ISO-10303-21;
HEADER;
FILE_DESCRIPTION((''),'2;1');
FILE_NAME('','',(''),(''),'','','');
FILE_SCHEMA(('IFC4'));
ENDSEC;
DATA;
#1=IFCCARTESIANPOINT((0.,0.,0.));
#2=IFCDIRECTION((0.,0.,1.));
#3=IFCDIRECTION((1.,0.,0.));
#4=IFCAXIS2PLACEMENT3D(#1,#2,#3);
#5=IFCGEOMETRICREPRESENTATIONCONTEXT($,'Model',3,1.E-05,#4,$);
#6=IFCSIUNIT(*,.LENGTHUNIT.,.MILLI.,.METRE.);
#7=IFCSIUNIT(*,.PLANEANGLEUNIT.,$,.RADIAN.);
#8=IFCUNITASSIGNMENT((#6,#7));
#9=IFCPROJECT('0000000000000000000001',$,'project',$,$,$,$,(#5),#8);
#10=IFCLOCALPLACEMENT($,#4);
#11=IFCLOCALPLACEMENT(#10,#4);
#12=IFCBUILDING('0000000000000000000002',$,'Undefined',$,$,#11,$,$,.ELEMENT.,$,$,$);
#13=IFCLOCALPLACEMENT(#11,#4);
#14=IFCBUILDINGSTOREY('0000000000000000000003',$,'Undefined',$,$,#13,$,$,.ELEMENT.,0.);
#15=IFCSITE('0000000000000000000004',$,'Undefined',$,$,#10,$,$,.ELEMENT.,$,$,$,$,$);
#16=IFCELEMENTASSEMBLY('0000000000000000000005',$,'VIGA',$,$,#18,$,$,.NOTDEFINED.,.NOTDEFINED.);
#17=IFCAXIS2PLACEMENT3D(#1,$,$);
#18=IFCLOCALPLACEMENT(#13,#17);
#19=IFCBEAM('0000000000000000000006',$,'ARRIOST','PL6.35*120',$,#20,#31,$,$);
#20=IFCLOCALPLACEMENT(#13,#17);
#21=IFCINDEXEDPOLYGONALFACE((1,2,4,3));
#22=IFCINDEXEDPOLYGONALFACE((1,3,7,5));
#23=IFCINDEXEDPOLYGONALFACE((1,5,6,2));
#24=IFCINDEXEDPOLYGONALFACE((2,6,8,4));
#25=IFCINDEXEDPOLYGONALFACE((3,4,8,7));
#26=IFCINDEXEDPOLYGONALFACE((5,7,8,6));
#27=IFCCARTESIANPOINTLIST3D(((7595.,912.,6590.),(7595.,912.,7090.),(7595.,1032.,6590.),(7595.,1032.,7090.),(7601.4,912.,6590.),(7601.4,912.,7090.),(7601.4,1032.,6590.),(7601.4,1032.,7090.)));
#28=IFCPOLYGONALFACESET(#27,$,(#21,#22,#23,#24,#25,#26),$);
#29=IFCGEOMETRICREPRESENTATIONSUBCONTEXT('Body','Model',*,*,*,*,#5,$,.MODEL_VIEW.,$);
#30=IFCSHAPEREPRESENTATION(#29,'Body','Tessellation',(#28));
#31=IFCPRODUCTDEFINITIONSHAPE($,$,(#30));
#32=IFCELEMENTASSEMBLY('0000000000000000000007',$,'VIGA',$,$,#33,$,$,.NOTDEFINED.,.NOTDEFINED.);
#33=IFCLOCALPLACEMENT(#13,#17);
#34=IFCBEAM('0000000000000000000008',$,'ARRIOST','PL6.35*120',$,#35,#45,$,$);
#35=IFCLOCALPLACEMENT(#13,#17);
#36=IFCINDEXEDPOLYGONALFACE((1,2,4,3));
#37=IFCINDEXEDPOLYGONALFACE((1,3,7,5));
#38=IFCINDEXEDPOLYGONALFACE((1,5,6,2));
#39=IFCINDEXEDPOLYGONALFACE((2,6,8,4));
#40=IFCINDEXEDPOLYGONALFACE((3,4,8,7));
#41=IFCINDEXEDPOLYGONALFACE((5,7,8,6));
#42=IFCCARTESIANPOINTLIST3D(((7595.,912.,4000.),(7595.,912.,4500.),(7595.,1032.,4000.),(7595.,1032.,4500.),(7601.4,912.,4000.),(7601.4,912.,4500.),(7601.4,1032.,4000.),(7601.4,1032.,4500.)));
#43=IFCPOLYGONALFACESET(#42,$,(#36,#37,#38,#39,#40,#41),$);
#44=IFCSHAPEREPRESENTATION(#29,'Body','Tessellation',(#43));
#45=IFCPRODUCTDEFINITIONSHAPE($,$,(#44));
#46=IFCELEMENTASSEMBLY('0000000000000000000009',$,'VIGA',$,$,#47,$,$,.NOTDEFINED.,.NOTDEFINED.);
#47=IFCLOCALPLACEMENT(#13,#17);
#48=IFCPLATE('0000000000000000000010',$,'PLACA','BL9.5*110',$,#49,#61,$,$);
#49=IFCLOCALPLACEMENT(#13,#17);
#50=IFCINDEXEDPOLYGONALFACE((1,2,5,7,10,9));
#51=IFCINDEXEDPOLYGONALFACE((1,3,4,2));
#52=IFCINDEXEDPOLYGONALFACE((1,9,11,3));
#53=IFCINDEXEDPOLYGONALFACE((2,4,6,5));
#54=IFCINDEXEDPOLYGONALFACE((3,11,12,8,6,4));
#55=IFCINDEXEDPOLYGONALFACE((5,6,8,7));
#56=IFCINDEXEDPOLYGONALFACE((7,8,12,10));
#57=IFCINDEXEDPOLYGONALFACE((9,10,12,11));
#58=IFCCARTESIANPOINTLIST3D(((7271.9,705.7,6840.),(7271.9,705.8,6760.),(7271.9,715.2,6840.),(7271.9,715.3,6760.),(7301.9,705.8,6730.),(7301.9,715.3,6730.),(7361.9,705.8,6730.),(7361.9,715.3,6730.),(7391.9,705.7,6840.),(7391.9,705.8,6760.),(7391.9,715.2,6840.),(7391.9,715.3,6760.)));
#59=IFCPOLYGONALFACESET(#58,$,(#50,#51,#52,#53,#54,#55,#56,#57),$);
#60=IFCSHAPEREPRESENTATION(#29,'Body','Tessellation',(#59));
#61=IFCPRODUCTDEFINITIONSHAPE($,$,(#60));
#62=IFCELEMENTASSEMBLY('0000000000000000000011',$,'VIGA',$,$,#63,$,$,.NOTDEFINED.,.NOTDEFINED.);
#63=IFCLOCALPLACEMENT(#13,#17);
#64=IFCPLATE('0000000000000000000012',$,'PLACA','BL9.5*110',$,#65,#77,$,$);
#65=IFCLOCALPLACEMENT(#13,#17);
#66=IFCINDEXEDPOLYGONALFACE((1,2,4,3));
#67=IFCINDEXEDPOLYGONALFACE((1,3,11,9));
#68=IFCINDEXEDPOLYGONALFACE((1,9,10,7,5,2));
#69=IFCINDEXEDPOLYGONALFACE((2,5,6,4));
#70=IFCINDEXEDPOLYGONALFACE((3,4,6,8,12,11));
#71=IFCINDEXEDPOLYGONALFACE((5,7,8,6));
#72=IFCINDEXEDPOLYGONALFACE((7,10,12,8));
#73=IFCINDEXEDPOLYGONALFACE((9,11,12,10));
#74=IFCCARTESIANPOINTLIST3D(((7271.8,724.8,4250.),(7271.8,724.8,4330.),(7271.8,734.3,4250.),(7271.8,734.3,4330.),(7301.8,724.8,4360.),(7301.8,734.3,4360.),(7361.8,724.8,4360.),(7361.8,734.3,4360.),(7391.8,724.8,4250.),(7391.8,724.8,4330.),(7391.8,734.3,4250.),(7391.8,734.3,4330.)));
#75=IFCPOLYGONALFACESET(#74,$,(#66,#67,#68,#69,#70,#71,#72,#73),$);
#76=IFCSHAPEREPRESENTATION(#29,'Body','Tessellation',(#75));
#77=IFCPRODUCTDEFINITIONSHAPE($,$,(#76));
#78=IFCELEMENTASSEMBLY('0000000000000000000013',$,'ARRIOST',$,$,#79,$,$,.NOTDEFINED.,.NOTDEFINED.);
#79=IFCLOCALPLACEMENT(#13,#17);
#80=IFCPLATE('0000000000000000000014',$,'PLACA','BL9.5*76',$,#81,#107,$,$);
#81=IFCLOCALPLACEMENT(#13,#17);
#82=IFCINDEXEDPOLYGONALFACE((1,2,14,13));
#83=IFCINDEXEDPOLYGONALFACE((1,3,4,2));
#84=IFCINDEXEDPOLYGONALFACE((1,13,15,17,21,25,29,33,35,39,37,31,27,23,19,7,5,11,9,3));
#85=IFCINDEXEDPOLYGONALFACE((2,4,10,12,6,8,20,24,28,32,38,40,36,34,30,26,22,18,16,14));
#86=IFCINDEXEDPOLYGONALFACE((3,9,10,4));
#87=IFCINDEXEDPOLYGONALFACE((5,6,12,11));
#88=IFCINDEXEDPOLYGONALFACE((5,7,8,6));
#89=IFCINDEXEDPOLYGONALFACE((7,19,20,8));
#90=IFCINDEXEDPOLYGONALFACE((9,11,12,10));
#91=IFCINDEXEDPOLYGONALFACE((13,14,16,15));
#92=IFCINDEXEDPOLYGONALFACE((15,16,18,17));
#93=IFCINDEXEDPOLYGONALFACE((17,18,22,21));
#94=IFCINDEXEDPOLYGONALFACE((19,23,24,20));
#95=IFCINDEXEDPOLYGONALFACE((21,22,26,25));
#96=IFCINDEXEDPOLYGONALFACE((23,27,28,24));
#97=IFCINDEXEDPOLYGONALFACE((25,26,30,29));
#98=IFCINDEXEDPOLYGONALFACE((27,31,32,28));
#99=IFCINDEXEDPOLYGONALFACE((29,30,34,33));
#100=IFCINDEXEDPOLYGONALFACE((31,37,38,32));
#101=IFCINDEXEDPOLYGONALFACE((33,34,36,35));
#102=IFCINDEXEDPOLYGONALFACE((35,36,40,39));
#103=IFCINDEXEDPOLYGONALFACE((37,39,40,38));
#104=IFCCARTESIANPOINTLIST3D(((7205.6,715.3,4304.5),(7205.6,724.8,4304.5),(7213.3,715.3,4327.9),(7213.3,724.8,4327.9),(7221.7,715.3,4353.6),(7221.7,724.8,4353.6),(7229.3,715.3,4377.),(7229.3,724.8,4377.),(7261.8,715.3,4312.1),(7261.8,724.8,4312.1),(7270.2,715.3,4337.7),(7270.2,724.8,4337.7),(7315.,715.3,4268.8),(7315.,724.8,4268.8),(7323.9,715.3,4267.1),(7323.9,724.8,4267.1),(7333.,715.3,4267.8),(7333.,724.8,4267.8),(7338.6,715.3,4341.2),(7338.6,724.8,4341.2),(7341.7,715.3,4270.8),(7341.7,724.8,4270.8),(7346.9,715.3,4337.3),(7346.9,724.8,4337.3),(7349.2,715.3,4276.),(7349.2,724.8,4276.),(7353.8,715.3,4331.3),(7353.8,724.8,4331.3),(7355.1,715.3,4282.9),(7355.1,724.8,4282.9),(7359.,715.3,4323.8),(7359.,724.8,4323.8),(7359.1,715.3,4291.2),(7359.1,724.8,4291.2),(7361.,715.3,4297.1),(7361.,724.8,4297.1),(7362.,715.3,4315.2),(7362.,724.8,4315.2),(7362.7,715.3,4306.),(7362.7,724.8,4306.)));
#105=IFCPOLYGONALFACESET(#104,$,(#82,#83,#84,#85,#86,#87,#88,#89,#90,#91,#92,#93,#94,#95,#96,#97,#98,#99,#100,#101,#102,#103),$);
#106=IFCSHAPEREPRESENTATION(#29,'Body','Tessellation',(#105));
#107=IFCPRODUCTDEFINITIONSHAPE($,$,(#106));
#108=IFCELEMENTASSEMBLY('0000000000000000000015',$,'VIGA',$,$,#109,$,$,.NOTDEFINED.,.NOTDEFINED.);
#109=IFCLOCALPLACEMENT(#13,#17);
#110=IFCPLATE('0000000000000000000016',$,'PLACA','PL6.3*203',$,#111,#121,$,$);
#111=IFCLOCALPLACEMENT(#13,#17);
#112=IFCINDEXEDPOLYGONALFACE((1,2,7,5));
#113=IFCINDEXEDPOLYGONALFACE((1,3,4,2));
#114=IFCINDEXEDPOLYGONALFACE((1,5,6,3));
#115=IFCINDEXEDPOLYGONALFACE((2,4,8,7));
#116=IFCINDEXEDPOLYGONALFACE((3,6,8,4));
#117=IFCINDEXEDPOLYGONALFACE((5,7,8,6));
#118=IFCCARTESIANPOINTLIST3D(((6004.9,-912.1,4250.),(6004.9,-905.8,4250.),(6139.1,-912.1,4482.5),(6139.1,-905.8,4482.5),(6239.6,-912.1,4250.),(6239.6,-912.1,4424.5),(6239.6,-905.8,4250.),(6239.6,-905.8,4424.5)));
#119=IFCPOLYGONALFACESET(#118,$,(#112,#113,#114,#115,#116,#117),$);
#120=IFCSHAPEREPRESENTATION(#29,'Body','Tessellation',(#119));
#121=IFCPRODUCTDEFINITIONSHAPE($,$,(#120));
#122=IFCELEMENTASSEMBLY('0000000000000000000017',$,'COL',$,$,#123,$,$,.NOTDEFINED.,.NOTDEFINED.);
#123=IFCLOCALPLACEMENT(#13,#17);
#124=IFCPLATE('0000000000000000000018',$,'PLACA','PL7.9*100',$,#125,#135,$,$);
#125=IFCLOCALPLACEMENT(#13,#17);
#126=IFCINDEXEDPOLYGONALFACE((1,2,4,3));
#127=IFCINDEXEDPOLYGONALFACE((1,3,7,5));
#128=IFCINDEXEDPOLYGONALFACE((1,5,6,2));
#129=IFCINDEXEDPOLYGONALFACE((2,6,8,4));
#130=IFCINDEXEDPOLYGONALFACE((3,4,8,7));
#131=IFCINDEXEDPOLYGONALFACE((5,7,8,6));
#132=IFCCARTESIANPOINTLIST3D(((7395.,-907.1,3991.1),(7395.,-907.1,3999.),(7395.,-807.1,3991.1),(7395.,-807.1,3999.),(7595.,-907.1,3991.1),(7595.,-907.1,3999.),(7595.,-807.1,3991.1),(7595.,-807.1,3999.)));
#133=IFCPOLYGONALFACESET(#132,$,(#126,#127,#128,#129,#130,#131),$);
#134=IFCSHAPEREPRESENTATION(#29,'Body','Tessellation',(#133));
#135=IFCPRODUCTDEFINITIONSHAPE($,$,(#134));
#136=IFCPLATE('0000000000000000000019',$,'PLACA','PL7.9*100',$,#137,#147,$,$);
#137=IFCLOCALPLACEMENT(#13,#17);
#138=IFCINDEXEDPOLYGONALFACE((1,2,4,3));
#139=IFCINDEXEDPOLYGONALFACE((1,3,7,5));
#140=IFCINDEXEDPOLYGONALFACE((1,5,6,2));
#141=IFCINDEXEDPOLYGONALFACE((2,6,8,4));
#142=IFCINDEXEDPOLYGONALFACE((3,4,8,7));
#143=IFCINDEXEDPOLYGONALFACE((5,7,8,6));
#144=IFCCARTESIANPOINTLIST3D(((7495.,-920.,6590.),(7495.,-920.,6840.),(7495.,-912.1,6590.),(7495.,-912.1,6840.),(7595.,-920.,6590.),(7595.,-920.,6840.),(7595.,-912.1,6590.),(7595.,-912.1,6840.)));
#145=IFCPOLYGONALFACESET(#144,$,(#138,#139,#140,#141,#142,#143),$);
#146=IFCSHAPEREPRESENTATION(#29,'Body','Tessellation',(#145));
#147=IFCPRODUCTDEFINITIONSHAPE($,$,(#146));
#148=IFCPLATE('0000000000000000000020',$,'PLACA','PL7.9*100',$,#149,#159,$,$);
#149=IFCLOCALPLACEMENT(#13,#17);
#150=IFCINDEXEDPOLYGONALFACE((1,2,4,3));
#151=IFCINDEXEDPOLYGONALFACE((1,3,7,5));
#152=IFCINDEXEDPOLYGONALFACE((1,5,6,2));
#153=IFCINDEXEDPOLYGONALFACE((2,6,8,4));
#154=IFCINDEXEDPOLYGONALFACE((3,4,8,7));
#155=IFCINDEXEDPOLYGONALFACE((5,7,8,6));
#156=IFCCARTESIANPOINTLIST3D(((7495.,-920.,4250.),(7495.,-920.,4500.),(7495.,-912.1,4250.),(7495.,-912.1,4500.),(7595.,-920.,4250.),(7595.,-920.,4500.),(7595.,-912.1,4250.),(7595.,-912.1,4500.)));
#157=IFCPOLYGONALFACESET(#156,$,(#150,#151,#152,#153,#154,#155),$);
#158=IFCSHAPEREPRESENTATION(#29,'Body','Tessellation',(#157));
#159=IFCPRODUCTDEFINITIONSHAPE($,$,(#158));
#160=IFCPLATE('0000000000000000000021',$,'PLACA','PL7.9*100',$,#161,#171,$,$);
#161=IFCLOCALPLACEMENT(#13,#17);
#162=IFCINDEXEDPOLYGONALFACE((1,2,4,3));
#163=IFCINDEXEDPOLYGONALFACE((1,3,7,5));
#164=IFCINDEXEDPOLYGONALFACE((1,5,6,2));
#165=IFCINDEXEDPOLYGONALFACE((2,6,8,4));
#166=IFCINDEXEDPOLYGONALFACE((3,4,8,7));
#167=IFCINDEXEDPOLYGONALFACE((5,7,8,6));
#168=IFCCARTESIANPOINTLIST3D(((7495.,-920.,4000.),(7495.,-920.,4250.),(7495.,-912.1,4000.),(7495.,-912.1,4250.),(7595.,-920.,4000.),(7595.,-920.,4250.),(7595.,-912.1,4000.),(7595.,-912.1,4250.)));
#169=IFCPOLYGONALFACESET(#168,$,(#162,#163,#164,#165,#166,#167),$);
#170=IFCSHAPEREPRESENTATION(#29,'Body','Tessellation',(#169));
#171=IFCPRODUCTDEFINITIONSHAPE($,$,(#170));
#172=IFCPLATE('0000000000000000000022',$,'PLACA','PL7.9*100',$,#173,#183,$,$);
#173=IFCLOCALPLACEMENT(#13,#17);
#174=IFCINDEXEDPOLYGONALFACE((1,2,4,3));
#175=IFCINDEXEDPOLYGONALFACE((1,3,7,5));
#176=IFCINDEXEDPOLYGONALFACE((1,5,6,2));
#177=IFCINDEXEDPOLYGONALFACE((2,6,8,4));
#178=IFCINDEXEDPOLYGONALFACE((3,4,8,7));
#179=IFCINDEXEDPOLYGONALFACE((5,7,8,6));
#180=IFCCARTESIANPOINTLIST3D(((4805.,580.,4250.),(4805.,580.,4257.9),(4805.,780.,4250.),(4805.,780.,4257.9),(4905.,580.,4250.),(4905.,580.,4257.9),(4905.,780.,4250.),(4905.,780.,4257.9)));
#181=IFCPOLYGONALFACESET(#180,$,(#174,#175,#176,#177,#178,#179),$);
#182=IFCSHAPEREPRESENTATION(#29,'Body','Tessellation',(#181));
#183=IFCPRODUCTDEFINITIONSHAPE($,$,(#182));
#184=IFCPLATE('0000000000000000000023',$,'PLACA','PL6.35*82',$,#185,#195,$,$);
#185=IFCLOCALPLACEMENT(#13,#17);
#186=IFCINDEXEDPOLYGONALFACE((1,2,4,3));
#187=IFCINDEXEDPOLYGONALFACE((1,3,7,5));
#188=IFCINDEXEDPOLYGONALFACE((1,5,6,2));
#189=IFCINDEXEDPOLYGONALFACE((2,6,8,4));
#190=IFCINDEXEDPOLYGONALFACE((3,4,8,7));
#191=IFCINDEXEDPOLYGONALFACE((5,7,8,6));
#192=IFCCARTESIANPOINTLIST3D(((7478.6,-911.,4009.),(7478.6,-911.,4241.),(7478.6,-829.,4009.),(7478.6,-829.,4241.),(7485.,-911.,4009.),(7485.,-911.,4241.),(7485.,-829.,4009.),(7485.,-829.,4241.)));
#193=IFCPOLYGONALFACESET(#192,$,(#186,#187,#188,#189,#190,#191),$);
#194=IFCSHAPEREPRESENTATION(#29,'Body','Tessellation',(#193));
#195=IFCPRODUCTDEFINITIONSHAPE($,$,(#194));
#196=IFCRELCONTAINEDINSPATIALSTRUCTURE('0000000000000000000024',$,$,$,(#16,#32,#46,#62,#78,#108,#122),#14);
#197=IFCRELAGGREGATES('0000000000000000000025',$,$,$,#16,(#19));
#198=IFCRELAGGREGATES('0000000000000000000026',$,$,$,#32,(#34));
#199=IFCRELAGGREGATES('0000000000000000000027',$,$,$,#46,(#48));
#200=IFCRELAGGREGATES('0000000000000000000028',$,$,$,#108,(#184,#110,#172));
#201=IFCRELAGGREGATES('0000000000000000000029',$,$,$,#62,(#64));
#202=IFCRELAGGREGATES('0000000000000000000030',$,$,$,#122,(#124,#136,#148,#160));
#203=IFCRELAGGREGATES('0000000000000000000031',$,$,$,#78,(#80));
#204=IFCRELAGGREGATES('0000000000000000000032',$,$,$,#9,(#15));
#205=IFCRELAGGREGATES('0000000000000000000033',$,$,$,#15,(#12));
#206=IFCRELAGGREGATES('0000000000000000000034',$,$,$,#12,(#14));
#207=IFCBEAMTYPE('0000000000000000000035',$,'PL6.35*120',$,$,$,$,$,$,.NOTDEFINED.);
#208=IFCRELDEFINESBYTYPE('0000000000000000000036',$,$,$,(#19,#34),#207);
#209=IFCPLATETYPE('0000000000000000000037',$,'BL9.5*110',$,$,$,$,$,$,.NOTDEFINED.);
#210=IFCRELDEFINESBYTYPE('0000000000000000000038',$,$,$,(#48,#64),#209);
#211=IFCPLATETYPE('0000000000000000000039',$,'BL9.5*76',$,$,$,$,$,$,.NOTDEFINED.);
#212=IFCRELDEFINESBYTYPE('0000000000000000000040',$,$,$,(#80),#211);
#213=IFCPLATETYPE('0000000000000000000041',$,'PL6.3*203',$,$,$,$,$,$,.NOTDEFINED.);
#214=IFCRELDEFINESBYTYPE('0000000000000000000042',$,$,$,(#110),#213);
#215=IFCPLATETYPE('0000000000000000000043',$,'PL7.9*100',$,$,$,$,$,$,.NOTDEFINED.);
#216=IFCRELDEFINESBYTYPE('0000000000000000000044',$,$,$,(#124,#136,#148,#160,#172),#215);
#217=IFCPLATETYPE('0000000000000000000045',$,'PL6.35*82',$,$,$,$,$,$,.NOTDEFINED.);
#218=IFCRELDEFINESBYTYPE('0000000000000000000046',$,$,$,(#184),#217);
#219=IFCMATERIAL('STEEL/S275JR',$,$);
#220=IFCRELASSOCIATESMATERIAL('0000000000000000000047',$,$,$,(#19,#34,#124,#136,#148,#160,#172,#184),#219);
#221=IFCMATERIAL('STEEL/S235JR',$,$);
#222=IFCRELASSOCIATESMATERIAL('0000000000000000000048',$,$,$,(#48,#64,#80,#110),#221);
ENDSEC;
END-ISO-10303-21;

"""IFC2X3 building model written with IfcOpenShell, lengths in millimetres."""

from ifc_helpers import new_model, si_unit, frame, frame_2d, origin_with_axes, origin_2d_with_axis, place, context, subcontext, project, spatial, polyline, circle_curve, parameter, trimmed, segment, composite_curve, rectangle, outline, extrude, boolean, material, type_object, element, aggregate, save


model = new_model("IFC2X3")

# Units and contexts
model_context = context("Model", 3, precision=1e-05, world=origin_with_axes())
body_context = subcontext(model_context, "Body", "Model", "MODEL_VIEW")
ifc_project = project(units=[si_unit("LENGTHUNIT", "METRE", prefix="MILLI"), si_unit("PLANEANGLEUNIT", "RADIAN")], contexts=[model_context])

# Site, building, storey
site_placement = place(None, origin_with_axes())
site = spatial("IfcSite", under=ifc_project, at=site_placement, Name="Undefined", CompositionType="ELEMENT")
building_placement = place(site_placement, origin_with_axes())
building = spatial("IfcBuilding", under=site, at=building_placement, Name="Undefined", CompositionType="ELEMENT")
storey_placement = place(building_placement, origin_with_axes())
storey = spatial("IfcBuildingStorey", under=building, at=storey_placement, Name="Undefined", CompositionType="ELEMENT", Elevation=0.0)

# Element assemblies, beams
assembly_1_placement = place(storey_placement, origin_with_axes())
assembly_1 = element("IfcElementAssembly", 1, at=assembly_1_placement, inside=storey, Name="VIGA", AssemblyPlace="NOTDEFINED", PredefinedType="NOTDEFINED")
ifc_material_1 = material(Name="STEEL/S275JR")
beam_type = type_object("IfcBeamType", Name="PL6.35*120", PredefinedType="NOTDEFINED")
beam_1_placement = place(assembly_1_placement, frame((7598.2, 972.0, 6590.0), z_axis=(0.0, 1.0, 0.0), x_axis=(0.0, 0.0, 1.0)))
beam_1 = element("IfcBeam", 2, at=beam_1_placement, type_object=beam_type, material=ifc_material_1, Name="ARRIOST", Description="PL6.35*120", context=body_context, shape_type="SweptSolid", body=[
    extrude(rectangle(XDim=6.3, YDim=120.0, at=origin_2d_with_axis()), frame((500.0, 0.0, 0.0), z_axis=(-1.0, 0.0, 0.0), x_axis=(0.0, -1.0, 0.0)), (0.0, 0.0, 1.0), 500.0),
])
aggregate(assembly_1, [beam_1])
assembly_2_placement = place(storey_placement, origin_with_axes())
assembly_2 = element("IfcElementAssembly", 3, at=assembly_2_placement, inside=storey, Name="VIGA", AssemblyPlace="NOTDEFINED", PredefinedType="NOTDEFINED")
beam_2_placement = place(assembly_2_placement, frame((7598.2, 972.0, 4000.0), z_axis=(0.0, 1.0, 0.0), x_axis=(0.0, 0.0, 1.0)))
beam_2 = element("IfcBeam", 4, at=beam_2_placement, type_object=beam_type, material=ifc_material_1, Name="ARRIOST", Description="PL6.35*120", context=body_context, shape_type="SweptSolid", body=[
    extrude(rectangle(XDim=6.3, YDim=120.0, at=origin_2d_with_axis()), frame((500.0, 0.0, 0.0), z_axis=(-1.0, 0.0, 0.0), x_axis=(0.0, -1.0, 0.0)), (0.0, 0.0, 1.0), 500.0),
])
aggregate(assembly_2, [beam_2])

# Element assemblies, plates
assembly_3_placement = place(storey_placement, origin_with_axes())
assembly_3 = element("IfcElementAssembly", 5, at=assembly_3_placement, inside=storey, Name="VIGA", AssemblyPlace="NOTDEFINED", PredefinedType="NOTDEFINED")
ifc_material_2 = material(Name="STEEL/S235JR")
plate_type_1 = type_object("IfcPlateType", Name="BL9.5*110", PredefinedType="NOTDEFINED")
plate_1_placement = place(assembly_3_placement, frame((7271.9, 710.5, 6760.0), z_axis=(0.0, 1.0, 0.000014), x_axis=(0.0, -0.000014, 1.0)))
plate_1 = element("IfcPlate", 6, at=plate_1_placement, type_object=plate_type_1, material=ifc_material_2, Name="PLACA", Description="BL9.5*110", context=body_context, shape_type="SweptSolid", body=[
    extrude(outline(polyline([(0.0, 0.0), (80.0, 0.0), (80.0, 120.0), (0.0, 120.0), (-30.0, 90.0), (-30.0, 30.0), (0.0, 0.0)])), frame((0.0, 0.0, -4.7), z_axis=(0.0, 0.0, 1.0), x_axis=(1.0, 0.0, 0.0)), (0.0, 0.0, 1.0), 9.5),
])
aggregate(assembly_3, [plate_1])
assembly_4_placement = place(storey_placement, origin_with_axes())
assembly_4 = element("IfcElementAssembly", 7, at=assembly_4_placement, inside=storey, Name="VIGA", AssemblyPlace="NOTDEFINED", PredefinedType="NOTDEFINED")
plate_2_placement = place(assembly_4_placement, frame((7271.8, 729.5, 4330.0), z_axis=(0.0, -1.0, -0.000007), x_axis=(0.0, 0.000007, -1.0)))
plate_2 = element("IfcPlate", 8, at=plate_2_placement, type_object=plate_type_1, material=ifc_material_2, Name="PLACA", Description="BL9.5*110", context=body_context, shape_type="SweptSolid", body=[
    extrude(outline(polyline([(0.0, 0.0), (80.0, 0.0), (80.0, 120.0), (0.0, 120.0), (-30.0, 90.0), (-30.0, 30.0), (0.0, 0.0)])), frame((0.0, 0.0, -4.7), z_axis=(0.0, 0.0, 1.0), x_axis=(1.0, 0.0, 0.0)), (0.0, 0.0, 1.0), 9.5),
])
assembly_5_placement = place(storey_placement, origin_with_axes())
assembly_5 = element("IfcElementAssembly", 9, at=assembly_5_placement, inside=storey, Name="ARRIOST", AssemblyPlace="NOTDEFINED", PredefinedType="NOTDEFINED")
plate_type_2 = type_object("IfcPlateType", Name="BL9.5*76", PredefinedType="NOTDEFINED")
plate_3_placement = place(assembly_5_placement, frame((7348.2, 720.0, 4257.9), z_axis=(0.0, -1.0, -0.000007), x_axis=(0.310823, -0.000007, 0.950468)))
plate_3 = element("IfcPlate", 10, at=plate_3_placement, type_object=plate_type_2, material=ifc_material_2, Name="PLACA", Description="BL9.5*76", context=body_context, shape_type="CSG", body=[
    boolean("DIFFERENCE", extrude(outline(composite_curve([segment(trimmed(circle_curve(frame_2d((35.0, 35.0), x_axis=(-1.0, 0.0)), 35.0), [parameter(0.0)], [parameter(1.570796)], True, "PARAMETER"), True, "CONTINUOUS"), segment(polyline([(35.0, 0.0), (41.2, 0.0)]), True, "CONTINUOUS"), segment(trimmed(circle_curve(frame_2d((41.2, 35.0), x_axis=(0.0, -1.0)), 35.0), [parameter(0.0)], [parameter(1.570796)], True, "PARAMETER"), True, "CONTINUOUS"), segment(polyline([(76.2, 35.0), (76.2, 150.0), (0.0, 150.0), (0.0, 35.0)]), True, "CONTINUOUS")], self_intersect=True)), frame((0.0, 0.0, -4.7), z_axis=(0.0, 0.0, 1.0), x_axis=(1.0, 0.0, 0.0)), (0.0, 0.0, 1.0), 9.5), extrude(rectangle(XDim=27.0, YDim=27.0, at=origin_2d_with_axis()), frame((38.1, 250.0, 0.0), z_axis=(0.0, -1.0, 0.0), x_axis=(1.0, 0.0, 0.0)), (0.0, 0.0, 1.0), 151.0)),
])
assembly_6_placement = place(storey_placement, origin_with_axes())
assembly_6 = element("IfcElementAssembly", 11, at=assembly_6_placement, inside=storey, Name="VIGA", AssemblyPlace="NOTDEFINED", PredefinedType="NOTDEFINED")
plate_type_3 = type_object("IfcPlateType", Name="PL6.3*203", PredefinedType="NOTDEFINED")
plate_4_placement = place(assembly_6_placement, frame((6239.6, -909.0, 4250.0), z_axis=(0.0, 1.0, 0.0), x_axis=(-1.0, 0.0, 0.0)))
plate_4 = element("IfcPlate", 12, at=plate_4_placement, type_object=plate_type_3, material=ifc_material_2, Name="PLACA", Description="PL6.3*203", context=body_context, shape_type="SweptSolid", body=[
    extrude(outline(polyline([(0.0, 0.0), (234.7, 0.0), (100.5, 232.5), (0.0, 174.5), (0.0, 0.0)])), frame((0.0, 0.0, -3.1), z_axis=(0.0, 0.0, 1.0), x_axis=(1.0, 0.0, 0.0)), (0.0, 0.0, 1.0), 6.3),
])

# Element assembly, plates
assembly_7_placement = place(storey_placement, origin_with_axes())
assembly_7 = element("IfcElementAssembly", 13, at=assembly_7_placement, inside=storey, Name="COL", AssemblyPlace="NOTDEFINED", PredefinedType="NOTDEFINED")
plate_type_4 = type_object("IfcPlateType", Name="PL7.9*100", PredefinedType="NOTDEFINED")
plate_5_placement = place(assembly_7_placement, frame((7395.0, -807.1, 3995.0), z_axis=(0.0, 0.0, 1.0), x_axis=(0.0, -1.0, 0.0)))
plate_5 = element("IfcPlate", 14, at=plate_5_placement, type_object=plate_type_4, material=ifc_material_1, Name="PLACA", Description="PL7.9*100", context=body_context, shape_type="SweptSolid", body=[
    extrude(outline(polyline([(0.0, 0.0), (100.0, 0.0), (100.0, 200.0), (0.0, 200.0), (0.0, 0.0)])), frame((0.0, 0.0, -4.0), z_axis=(0.0, 0.0, 1.0), x_axis=(1.0, 0.0, 0.0)), (0.0, 0.0, 1.0), 7.9),
])
plate_6_placement = place(assembly_7_placement, frame((7495.0, -916.0, 6590.0), z_axis=(0.0, 1.0, 0.0), x_axis=(0.0, 0.0, 1.0)))
plate_6 = element("IfcPlate", 15, at=plate_6_placement, type_object=plate_type_4, material=ifc_material_1, Name="PLACA", Description="PL7.9*100", context=body_context, shape_type="SweptSolid", body=[
    extrude(outline(polyline([(0.0, 0.0), (250.0, 0.0), (250.0, 100.0), (0.0, 100.0), (0.0, 0.0)])), frame((0.0, 0.0, -4.0), z_axis=(0.0, 0.0, 1.0), x_axis=(1.0, 0.0, 0.0)), (0.0, 0.0, 1.0), 7.9),
])
plate_7_placement = place(assembly_7_placement, frame((7495.0, -916.0, 4250.0), z_axis=(0.0, 1.0, 0.0), x_axis=(0.0, 0.0, 1.0)))
plate_7 = element("IfcPlate", 16, at=plate_7_placement, type_object=plate_type_4, material=ifc_material_1, Name="PLACA", Description="PL7.9*100", context=body_context, shape_type="SweptSolid", body=[
    extrude(outline(polyline([(0.0, 0.0), (250.0, 0.0), (250.0, 100.0), (0.0, 100.0), (0.0, 0.0)])), frame((0.0, 0.0, -4.0), z_axis=(0.0, 0.0, 1.0), x_axis=(1.0, 0.0, 0.0)), (0.0, 0.0, 1.0), 7.9),
])
plate_8_placement = place(assembly_7_placement, frame((7495.0, -916.0, 4000.0), z_axis=(0.0, 1.0, 0.0), x_axis=(0.0, 0.0, 1.0)))
plate_8 = element("IfcPlate", 17, at=plate_8_placement, type_object=plate_type_4, material=ifc_material_1, Name="PLACA", Description="PL7.9*100", context=body_context, shape_type="SweptSolid", body=[
    extrude(outline(polyline([(0.0, 0.0), (250.0, 0.0), (250.0, 100.0), (0.0, 100.0), (0.0, 0.0)])), frame((0.0, 0.0, -4.0), z_axis=(0.0, 0.0, 1.0), x_axis=(1.0, 0.0, 0.0)), (0.0, 0.0, 1.0), 7.9),
])

# Plates
plate_9_placement = place(assembly_6_placement, frame((4905.0, 580.0, 4253.9), z_axis=(0.0, 0.0, -1.0), x_axis=(-1.0, 0.0, 0.0)))
plate_9 = element("IfcPlate", 18, at=plate_9_placement, type_object=plate_type_4, material=ifc_material_1, Name="PLACA", Description="PL7.9*100", context=body_context, shape_type="SweptSolid", body=[
    extrude(outline(polyline([(0.0, 0.0), (100.0, 0.0), (100.0, 200.0), (0.0, 200.0), (0.0, 0.0)])), frame((0.0, 0.0, -4.0), z_axis=(0.0, 0.0, 1.0), x_axis=(1.0, 0.0, 0.0)), (0.0, 0.0, 1.0), 7.9),
])
plate_type_5 = type_object("IfcPlateType", Name="PL6.35*82", PredefinedType="NOTDEFINED")
plate_10_placement = place(assembly_6_placement, frame((7481.8, -911.0, 4241.0), z_axis=(-1.0, 0.0, 0.0), x_axis=(0.0, 1.0, 0.0)))
plate_10 = element("IfcPlate", 19, at=plate_10_placement, type_object=plate_type_5, material=ifc_material_1, Name="PLACA", Description="PL6.35*82", context=body_context, shape_type="SweptSolid", body=[
    extrude(outline(polyline([(0.0, 0.0), (82.0, 0.0), (82.0, 232.0), (0.0, 232.0), (0.0, 0.0)])), frame((0.0, 0.0, -3.2), z_axis=(0.0, 0.0, 1.0), x_axis=(1.0, 0.0, 0.0)), (0.0, 0.0, 1.0), 6.4),
])
aggregate(assembly_6, [plate_10, plate_4, plate_9])
aggregate(assembly_4, [plate_2])
aggregate(assembly_7, [plate_5, plate_6, plate_7, plate_8])

aggregate(assembly_5, [plate_3])

save(model, "model.ifc")
